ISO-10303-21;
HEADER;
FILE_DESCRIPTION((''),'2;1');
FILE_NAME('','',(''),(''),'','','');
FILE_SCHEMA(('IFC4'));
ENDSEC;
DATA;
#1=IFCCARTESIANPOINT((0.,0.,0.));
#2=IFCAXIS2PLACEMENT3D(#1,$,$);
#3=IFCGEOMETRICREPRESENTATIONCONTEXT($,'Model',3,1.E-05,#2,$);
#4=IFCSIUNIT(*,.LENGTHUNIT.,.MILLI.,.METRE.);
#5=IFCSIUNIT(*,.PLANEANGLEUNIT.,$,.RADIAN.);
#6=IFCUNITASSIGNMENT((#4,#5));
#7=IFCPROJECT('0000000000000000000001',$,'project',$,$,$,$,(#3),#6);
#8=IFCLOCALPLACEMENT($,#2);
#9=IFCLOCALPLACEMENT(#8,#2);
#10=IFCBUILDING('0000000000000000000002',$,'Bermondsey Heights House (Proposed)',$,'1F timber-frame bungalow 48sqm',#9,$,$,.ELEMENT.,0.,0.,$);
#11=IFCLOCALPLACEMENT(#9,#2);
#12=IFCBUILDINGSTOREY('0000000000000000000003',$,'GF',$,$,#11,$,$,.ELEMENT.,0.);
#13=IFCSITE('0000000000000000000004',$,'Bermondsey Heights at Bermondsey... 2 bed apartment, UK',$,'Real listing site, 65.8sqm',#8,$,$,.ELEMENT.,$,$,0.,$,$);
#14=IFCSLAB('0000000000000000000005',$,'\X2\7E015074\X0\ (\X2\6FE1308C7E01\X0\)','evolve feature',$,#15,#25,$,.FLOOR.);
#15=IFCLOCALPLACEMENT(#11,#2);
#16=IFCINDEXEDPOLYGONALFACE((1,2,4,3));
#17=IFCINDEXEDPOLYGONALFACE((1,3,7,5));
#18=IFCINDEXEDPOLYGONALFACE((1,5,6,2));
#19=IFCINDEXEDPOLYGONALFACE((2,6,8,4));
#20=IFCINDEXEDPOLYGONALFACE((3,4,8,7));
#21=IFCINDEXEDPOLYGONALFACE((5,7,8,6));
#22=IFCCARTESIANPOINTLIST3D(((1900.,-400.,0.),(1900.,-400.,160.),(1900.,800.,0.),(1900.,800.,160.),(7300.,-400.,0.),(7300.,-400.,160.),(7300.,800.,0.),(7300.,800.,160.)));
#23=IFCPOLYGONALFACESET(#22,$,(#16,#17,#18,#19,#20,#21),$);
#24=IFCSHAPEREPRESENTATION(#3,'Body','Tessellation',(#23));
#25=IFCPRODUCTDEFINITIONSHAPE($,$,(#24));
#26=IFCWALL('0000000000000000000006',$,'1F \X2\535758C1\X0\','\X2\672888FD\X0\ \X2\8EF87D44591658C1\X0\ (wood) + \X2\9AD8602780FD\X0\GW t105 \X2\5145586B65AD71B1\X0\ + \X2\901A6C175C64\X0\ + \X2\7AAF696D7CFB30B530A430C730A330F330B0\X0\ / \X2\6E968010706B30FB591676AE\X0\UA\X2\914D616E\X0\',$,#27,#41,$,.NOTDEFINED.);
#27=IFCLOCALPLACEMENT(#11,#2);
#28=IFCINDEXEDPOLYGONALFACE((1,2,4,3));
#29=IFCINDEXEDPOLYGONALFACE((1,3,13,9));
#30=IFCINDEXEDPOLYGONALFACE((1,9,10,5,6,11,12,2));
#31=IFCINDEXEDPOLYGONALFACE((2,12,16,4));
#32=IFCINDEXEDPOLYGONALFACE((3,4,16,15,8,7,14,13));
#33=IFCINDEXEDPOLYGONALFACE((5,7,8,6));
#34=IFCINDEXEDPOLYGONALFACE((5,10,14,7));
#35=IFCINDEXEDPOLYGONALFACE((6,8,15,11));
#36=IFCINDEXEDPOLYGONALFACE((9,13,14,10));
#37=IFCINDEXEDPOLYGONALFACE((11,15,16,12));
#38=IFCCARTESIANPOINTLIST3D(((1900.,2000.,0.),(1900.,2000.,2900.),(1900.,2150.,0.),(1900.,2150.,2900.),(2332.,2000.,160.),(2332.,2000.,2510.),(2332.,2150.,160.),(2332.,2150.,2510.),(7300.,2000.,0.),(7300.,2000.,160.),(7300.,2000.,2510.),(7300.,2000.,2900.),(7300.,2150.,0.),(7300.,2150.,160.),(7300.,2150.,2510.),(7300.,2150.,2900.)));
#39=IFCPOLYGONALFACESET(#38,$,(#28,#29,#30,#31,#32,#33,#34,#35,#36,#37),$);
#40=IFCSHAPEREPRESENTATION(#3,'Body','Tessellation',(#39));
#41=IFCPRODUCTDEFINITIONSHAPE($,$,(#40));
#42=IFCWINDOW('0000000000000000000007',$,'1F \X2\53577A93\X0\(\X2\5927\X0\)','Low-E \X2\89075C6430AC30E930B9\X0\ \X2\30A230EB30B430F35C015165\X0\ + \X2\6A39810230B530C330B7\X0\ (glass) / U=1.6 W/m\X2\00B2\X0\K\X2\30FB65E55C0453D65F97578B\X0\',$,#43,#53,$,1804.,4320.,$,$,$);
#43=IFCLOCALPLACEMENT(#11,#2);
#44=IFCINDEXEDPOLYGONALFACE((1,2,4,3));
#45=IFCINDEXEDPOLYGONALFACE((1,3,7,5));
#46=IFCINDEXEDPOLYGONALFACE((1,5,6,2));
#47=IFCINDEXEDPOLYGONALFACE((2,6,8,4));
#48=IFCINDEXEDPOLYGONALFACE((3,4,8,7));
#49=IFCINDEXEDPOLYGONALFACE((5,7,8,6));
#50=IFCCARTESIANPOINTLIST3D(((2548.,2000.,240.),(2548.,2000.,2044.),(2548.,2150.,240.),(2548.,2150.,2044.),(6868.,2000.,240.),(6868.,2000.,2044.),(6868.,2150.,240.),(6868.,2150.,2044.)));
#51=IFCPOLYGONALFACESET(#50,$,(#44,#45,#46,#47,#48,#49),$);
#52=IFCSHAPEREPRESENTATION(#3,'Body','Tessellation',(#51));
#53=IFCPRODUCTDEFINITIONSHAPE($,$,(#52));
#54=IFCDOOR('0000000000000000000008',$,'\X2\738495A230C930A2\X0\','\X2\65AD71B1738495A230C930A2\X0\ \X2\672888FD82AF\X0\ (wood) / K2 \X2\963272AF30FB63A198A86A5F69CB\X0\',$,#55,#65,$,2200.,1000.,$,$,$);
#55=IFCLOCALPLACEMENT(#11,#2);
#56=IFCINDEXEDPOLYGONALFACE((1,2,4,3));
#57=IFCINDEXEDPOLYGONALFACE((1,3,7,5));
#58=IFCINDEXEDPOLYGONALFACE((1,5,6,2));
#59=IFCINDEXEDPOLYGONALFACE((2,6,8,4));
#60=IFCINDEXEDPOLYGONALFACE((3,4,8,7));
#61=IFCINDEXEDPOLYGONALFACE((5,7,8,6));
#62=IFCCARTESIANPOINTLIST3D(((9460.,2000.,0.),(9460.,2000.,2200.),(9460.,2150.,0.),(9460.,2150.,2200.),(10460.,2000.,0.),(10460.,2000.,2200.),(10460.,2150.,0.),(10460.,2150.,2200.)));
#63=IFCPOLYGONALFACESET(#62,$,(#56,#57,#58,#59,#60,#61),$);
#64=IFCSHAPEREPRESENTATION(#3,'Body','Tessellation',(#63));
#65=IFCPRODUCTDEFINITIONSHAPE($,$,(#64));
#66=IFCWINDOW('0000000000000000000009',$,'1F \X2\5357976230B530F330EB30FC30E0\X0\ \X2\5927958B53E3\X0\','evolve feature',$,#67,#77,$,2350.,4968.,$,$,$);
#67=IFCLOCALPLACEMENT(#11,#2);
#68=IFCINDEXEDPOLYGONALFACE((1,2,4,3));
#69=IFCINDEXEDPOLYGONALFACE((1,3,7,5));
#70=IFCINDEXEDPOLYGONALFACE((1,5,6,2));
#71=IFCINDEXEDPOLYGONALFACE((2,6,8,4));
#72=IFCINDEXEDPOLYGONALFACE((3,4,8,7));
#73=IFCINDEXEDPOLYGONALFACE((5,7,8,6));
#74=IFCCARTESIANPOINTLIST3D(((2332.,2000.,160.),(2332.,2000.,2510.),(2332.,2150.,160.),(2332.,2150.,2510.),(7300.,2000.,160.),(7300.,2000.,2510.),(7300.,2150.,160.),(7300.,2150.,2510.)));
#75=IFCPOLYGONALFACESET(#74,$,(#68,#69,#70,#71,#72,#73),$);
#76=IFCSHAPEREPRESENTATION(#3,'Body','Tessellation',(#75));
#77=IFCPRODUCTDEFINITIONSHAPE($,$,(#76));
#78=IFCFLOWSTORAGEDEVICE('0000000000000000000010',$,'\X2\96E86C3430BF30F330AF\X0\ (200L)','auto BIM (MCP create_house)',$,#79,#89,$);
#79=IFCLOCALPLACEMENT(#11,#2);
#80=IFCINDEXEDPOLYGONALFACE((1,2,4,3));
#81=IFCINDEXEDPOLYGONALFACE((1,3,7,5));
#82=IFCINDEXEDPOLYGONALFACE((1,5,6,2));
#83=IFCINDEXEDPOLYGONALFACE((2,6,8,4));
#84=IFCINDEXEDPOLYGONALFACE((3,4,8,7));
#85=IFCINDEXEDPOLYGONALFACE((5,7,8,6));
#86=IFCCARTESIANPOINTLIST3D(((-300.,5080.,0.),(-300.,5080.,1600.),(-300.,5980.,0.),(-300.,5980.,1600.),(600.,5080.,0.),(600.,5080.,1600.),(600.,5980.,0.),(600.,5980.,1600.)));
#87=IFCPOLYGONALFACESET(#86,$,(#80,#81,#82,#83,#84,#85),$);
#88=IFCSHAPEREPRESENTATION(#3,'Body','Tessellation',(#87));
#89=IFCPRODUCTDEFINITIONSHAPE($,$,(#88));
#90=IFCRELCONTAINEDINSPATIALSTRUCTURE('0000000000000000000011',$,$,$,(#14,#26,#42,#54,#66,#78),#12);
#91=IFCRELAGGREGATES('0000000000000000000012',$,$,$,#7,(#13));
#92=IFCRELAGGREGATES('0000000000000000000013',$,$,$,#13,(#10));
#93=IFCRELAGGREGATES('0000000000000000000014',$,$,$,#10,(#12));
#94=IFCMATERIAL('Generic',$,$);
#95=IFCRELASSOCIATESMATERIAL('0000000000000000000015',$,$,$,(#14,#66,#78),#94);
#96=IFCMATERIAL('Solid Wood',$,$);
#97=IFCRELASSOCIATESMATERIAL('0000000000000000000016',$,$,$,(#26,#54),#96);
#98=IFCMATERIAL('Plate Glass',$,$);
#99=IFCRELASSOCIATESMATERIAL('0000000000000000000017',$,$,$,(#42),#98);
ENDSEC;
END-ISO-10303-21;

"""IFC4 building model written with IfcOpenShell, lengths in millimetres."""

from ifc_helpers import new_model, si_unit, frame, frame_2d, origin, place, context, project, spatial, rectangle, extrude, material, element, fill, save


model = new_model("IFC4")

# Units and contexts
model_context = context("Model", 3, precision=1e-05, world=origin())
ifc_project = project(units=[si_unit("LENGTHUNIT", "METRE", prefix="MILLI"), si_unit("PLANEANGLEUNIT", "RADIAN")], contexts=[model_context])

# Site, building, storey
site_placement = place(None, origin())
site = spatial("IfcSite", under=ifc_project, at=site_placement, Name="Bermondsey Heights at Bermondsey... 2 bed apartment, UK", ObjectType="Real listing site, 65.8sqm", CompositionType="ELEMENT", RefElevation=0.0)
building_placement = place(site_placement, origin())
building = spatial("IfcBuilding", under=site, at=building_placement, Name="Bermondsey Heights House (Proposed)", ObjectType="1F timber-frame bungalow 48sqm", CompositionType="ELEMENT", ElevationOfRefHeight=0.0, ElevationOfTerrain=0.0)
storey_placement = place(building_placement, origin())
storey = spatial("IfcBuildingStorey", under=building, at=storey_placement, Name="GF", CompositionType="ELEMENT", Elevation=0.0)

# Slab
ifc_material_1 = material(Name="Solid Wood")
ifc_material_2 = material(Name="Generic")
slab_1_placement = place(storey_placement, frame((950.0, -200.0, 0.0)))
element("IfcSlab", 1, at=slab_1_placement, inside=storey, material=ifc_material_2, Name="縁側 (濡れ縁)", Description="evolve feature", PredefinedType="FLOOR", context=model_context, shape_type="SweptSolid", body=[
    extrude(rectangle(XDim=5400.0, YDim=1200.0, at=frame_2d((2700.0, 600.0))), frame((950.0, -200.0, 0.0)), (0.0, 0.0, 1.0), 160.0),
])

# Wall, openings, windows, door
wall_1_placement = place(storey_placement, frame((950.0, 1000.0, 0.0)))
wall_1 = element("IfcWall", 2, at=wall_1_placement, inside=storey, material=ifc_material_1, Name="1F 南壁", Description="木製 軸組外壁 (wood) + 高性能GW t105 充填断熱 + 通気層 + 窯業系サイディング / 準耐火・外皮UA配慮", PredefinedType="NOTDEFINED", context=model_context, shape_type="SweptSolid", body=[
    extrude(rectangle(XDim=5400.0, YDim=150.0, at=frame_2d((2700.0, 75.0))), frame((950.0, 1000.0, 0.0)), (0.0, 0.0, 1.0), 2900.0),
])
opening_1_placement = place(storey_placement, frame((1274.0, 1000.0, 120.0)))
opening_1 = element("IfcOpeningElement", 3, at=opening_1_placement, cuts=wall_1, PredefinedType="NOTDEFINED", context=model_context, shape_type="SweptSolid", body=[
    extrude(rectangle(XDim=4320.0, YDim=150.0, at=frame_2d((2160.0, 75.0))), frame((1274.0, 1000.0, 120.0)), (0.0, 0.0, 1.0), 1804.0),
])
opening_2_placement = place(storey_placement, frame((4730.0, 1000.0, 0.0)))
opening_2 = element("IfcOpeningElement", 4, at=opening_2_placement, cuts=wall_1, PredefinedType="NOTDEFINED", context=model_context, shape_type="SweptSolid", body=[
    extrude(rectangle(XDim=1000.0, YDim=150.0, at=frame_2d((500.0, 75.0))), frame((4730.0, 1000.0, 0.0)), (0.0, 0.0, 1.0), 2200.0),
])
opening_3_placement = place(storey_placement, frame((1166.0, 1000.0, 80.0)))
opening_3 = element("IfcOpeningElement", 5, at=opening_3_placement, cuts=wall_1, PredefinedType="NOTDEFINED", context=model_context, shape_type="SweptSolid", body=[
    extrude(rectangle(XDim=4968.0, YDim=150.0, at=frame_2d((2484.0, 75.0))), frame((1166.0, 1000.0, 80.0)), (0.0, 0.0, 1.0), 2350.0),
])
ifc_material_3 = material(Name="Plate Glass")
window_1_placement = place(storey_placement, frame((1274.0, 1000.0, 120.0)))
window_1 = element("IfcWindow", 6, at=window_1_placement, inside=storey, material=ifc_material_3, Name="1F 南窓(大)", Description="Low-E 複層ガラス アルゴン封入 + 樹脂サッシ (glass) / U=1.6 W/m²K・日射取得型", OverallHeight=1804.0, OverallWidth=4320.0, context=model_context, shape_type="SweptSolid", body=[
    extrude(rectangle(XDim=4320.0, YDim=150.0, at=frame_2d((2160.0, 75.0))), frame((1274.0, 1000.0, 120.0)), (0.0, 0.0, 1.0), 1804.0),
])
fill(opening_1, window_1)
door_placement = place(storey_placement, frame((4730.0, 1000.0, 0.0)))
door = element("IfcDoor", 7, at=door_placement, inside=storey, material=ifc_material_1, Name="玄関ドア", Description="断熱玄関ドア 木製芯 (wood) / K2 防犯・採風機構", OverallHeight=2200.0, OverallWidth=1000.0, context=model_context, shape_type="SweptSolid", body=[
    extrude(rectangle(XDim=1000.0, YDim=150.0, at=frame_2d((500.0, 75.0))), frame((4730.0, 1000.0, 0.0)), (0.0, 0.0, 1.0), 2200.0),
])
fill(opening_2, door)
window_2_placement = place(storey_placement, frame((1166.0, 1000.0, 80.0)))
window_2 = element("IfcWindow", 8, at=window_2_placement, inside=storey, material=ifc_material_2, Name="1F 南面サンルーム 大開口", Description="evolve feature", OverallHeight=2350.0, OverallWidth=4968.0, context=model_context, shape_type="SweptSolid", body=[
    extrude(rectangle(XDim=4968.0, YDim=150.0, at=frame_2d((2484.0, 75.0))), frame((1166.0, 1000.0, 80.0)), (0.0, 0.0, 1.0), 2350.0),
])
fill(opening_3, window_2)

# Flow storage device
flow_storage_device_placement = place(storey_placement, frame((-150.0, 2540.0, 0.0)))
element("IfcFlowStorageDevice", 9, at=flow_storage_device_placement, inside=storey, material=ifc_material_2, Name="雨水タンク (200L)", Description="auto BIM (MCP create_house)", context=model_context, shape_type="SweptSolid", body=[
    extrude(rectangle(XDim=900.0, YDim=900.0, at=frame_2d((450.0, 450.0))), frame((-150.0, 2540.0, 0.0)), (0.0, 0.0, 1.0), 1600.0),
])

save(model, "model.ifc")
